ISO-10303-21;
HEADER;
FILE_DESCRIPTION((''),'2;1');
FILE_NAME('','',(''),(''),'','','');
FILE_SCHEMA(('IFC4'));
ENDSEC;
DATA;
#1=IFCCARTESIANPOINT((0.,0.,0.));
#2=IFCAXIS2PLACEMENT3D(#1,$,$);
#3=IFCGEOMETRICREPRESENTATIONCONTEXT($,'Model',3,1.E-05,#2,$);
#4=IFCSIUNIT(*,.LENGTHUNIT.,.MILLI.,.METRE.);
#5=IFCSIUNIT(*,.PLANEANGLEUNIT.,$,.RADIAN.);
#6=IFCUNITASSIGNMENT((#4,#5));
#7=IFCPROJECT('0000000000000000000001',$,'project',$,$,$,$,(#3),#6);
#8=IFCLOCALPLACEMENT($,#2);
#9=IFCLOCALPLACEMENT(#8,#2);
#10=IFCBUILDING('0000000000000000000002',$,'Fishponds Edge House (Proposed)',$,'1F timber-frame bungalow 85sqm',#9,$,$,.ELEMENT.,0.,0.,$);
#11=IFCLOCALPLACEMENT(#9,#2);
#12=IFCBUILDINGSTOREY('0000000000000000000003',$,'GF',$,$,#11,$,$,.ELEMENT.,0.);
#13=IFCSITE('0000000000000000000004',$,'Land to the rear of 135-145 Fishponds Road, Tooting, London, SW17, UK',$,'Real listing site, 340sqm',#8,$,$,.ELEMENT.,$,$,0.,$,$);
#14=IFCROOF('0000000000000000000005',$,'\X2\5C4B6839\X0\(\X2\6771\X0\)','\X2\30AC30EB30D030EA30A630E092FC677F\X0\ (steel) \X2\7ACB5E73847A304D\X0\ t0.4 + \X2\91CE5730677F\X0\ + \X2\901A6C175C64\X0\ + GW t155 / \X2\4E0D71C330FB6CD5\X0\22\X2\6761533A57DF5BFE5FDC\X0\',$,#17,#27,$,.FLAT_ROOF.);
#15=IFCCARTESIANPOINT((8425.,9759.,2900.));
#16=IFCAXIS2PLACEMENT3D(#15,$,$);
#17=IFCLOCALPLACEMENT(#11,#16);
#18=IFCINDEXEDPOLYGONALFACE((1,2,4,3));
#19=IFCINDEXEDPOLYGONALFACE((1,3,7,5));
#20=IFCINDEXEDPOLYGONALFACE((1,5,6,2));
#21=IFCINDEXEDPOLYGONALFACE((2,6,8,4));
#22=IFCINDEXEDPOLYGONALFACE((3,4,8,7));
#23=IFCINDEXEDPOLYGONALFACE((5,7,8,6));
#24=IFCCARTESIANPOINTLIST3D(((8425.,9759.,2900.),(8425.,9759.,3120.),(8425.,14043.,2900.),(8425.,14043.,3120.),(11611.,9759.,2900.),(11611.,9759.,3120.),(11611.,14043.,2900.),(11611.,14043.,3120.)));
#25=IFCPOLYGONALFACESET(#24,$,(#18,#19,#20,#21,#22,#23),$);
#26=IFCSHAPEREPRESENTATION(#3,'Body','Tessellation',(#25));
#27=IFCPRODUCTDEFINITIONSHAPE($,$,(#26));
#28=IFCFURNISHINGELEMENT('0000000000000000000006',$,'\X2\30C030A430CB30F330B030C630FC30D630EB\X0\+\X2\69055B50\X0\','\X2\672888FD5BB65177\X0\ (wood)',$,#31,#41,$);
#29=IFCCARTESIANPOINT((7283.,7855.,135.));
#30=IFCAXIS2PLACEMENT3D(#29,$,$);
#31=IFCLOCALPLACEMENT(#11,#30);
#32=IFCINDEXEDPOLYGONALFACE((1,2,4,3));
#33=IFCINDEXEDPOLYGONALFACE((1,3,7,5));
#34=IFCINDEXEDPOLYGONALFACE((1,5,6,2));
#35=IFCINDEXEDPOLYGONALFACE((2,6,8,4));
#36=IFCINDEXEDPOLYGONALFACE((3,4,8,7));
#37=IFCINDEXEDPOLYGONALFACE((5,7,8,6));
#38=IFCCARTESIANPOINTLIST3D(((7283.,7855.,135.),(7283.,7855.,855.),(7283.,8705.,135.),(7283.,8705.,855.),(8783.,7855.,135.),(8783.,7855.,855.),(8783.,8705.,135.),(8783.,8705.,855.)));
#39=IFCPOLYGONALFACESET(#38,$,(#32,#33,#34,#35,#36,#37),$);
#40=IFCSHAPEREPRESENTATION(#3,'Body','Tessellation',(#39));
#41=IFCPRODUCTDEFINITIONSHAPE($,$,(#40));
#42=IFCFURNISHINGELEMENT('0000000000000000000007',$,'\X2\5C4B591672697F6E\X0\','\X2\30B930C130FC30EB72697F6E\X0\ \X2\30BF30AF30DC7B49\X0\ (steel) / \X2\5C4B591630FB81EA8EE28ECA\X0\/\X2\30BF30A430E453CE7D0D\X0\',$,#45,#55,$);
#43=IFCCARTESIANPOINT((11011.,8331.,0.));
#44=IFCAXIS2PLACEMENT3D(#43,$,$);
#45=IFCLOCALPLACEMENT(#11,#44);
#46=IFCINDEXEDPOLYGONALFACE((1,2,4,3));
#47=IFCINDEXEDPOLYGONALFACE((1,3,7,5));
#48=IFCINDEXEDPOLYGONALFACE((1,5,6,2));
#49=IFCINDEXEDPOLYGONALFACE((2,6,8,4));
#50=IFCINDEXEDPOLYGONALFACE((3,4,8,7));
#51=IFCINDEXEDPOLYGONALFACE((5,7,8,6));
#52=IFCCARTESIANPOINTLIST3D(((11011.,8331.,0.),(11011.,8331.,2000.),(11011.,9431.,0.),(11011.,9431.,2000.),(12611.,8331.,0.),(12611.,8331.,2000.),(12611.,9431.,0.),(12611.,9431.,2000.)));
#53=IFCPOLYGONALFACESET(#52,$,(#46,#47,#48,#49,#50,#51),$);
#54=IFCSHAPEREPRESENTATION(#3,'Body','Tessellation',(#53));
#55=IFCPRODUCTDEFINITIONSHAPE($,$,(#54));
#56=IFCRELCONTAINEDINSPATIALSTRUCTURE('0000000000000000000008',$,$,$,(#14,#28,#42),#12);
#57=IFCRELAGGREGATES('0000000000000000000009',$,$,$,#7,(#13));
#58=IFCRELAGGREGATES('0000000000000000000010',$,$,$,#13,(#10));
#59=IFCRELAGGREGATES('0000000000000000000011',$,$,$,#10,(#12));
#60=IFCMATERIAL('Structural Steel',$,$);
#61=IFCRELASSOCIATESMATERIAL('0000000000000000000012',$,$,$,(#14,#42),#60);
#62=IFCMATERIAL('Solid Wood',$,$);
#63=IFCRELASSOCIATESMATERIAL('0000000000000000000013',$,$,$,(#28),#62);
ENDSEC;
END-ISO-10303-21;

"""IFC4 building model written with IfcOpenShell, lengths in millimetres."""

from ifc_helpers import new_model, si_unit, frame, frame_2d, origin, place, context, project, spatial, rectangle, extrude, material, element, save


model = new_model("IFC4")

# Units and contexts
model_context = context("Model", 3, precision=1e-05, world=origin())
ifc_project = project(units=[si_unit("LENGTHUNIT", "METRE", prefix="MILLI"), si_unit("PLANEANGLEUNIT", "RADIAN")], contexts=[model_context])

# Site, building, storey
site_placement = place(None, origin())
site = spatial("IfcSite", under=ifc_project, at=site_placement, Name="Land to the rear of 135-145 Fishponds Road, Tooting, London, SW17, UK", ObjectType="Real listing site, 340sqm", CompositionType="ELEMENT", RefElevation=0.0)
building_placement = place(site_placement, origin())
building = spatial("IfcBuilding", under=site, at=building_placement, Name="Fishponds Edge House (Proposed)", ObjectType="1F timber-frame bungalow 85sqm", CompositionType="ELEMENT", ElevationOfRefHeight=0.0, ElevationOfTerrain=0.0)
storey_placement = place(building_placement, origin())
storey = spatial("IfcBuildingStorey", under=building, at=storey_placement, Name="GF", CompositionType="ELEMENT", Elevation=0.0)

# Shared definitions
ifc_material_1 = material(Name="Solid Wood")

# Roof
ifc_material_2 = material(Name="Structural Steel")
roof_1_placement = place(storey_placement, frame((8425.0, 9759.0, 2900.0)))
element("IfcRoof", 1, at=roof_1_placement, inside=storey, material=ifc_material_2, Name="屋根(東)", Description="ガルバリウム鋼板 (steel) 立平葺き t0.4 + 野地板 + 通気層 + GW t155 / 不燃・法22条区域対応", PredefinedType="FLAT_ROOF", context=model_context, shape_type="SweptSolid", body=[
    extrude(rectangle(XDim=3186.0, YDim=4284.0, at=frame_2d((1593.0, 2142.0))), frame((8425.0, 9759.0, 2900.0)), (0.0, 0.0, 1.0), 220.0),
])

# Furnishing elements
furnishing_1_placement = place(storey_placement, frame((7283.0, 7855.0, 135.0)))
element("IfcFurnishingElement", 2, at=furnishing_1_placement, inside=storey, material=ifc_material_1, Name="ダイニングテーブル+椅子", Description="木製家具 (wood)", context=model_context, shape_type="SweptSolid", body=[
    extrude(rectangle(XDim=1500.0, YDim=850.0, at=frame_2d((750.0, 425.0))), frame((7283.0, 7855.0, 135.0)), (0.0, 0.0, 1.0), 720.0),
])
furnishing_2_placement = place(storey_placement, frame((11011.0, 8331.0, 0.0)))
element("IfcFurnishingElement", 3, at=furnishing_2_placement, inside=storey, material=ifc_material_2, Name="屋外物置", Description="スチール物置 タクボ等 (steel) / 屋外・自転車/タイヤ収納", context=model_context, shape_type="SweptSolid", body=[
    extrude(rectangle(XDim=1600.0, YDim=1100.0, at=frame_2d((800.0, 550.0))), frame((11011.0, 8331.0, 0.0)), (0.0, 0.0, 1.0), 2000.0),
])

save(model, "model.ifc")
